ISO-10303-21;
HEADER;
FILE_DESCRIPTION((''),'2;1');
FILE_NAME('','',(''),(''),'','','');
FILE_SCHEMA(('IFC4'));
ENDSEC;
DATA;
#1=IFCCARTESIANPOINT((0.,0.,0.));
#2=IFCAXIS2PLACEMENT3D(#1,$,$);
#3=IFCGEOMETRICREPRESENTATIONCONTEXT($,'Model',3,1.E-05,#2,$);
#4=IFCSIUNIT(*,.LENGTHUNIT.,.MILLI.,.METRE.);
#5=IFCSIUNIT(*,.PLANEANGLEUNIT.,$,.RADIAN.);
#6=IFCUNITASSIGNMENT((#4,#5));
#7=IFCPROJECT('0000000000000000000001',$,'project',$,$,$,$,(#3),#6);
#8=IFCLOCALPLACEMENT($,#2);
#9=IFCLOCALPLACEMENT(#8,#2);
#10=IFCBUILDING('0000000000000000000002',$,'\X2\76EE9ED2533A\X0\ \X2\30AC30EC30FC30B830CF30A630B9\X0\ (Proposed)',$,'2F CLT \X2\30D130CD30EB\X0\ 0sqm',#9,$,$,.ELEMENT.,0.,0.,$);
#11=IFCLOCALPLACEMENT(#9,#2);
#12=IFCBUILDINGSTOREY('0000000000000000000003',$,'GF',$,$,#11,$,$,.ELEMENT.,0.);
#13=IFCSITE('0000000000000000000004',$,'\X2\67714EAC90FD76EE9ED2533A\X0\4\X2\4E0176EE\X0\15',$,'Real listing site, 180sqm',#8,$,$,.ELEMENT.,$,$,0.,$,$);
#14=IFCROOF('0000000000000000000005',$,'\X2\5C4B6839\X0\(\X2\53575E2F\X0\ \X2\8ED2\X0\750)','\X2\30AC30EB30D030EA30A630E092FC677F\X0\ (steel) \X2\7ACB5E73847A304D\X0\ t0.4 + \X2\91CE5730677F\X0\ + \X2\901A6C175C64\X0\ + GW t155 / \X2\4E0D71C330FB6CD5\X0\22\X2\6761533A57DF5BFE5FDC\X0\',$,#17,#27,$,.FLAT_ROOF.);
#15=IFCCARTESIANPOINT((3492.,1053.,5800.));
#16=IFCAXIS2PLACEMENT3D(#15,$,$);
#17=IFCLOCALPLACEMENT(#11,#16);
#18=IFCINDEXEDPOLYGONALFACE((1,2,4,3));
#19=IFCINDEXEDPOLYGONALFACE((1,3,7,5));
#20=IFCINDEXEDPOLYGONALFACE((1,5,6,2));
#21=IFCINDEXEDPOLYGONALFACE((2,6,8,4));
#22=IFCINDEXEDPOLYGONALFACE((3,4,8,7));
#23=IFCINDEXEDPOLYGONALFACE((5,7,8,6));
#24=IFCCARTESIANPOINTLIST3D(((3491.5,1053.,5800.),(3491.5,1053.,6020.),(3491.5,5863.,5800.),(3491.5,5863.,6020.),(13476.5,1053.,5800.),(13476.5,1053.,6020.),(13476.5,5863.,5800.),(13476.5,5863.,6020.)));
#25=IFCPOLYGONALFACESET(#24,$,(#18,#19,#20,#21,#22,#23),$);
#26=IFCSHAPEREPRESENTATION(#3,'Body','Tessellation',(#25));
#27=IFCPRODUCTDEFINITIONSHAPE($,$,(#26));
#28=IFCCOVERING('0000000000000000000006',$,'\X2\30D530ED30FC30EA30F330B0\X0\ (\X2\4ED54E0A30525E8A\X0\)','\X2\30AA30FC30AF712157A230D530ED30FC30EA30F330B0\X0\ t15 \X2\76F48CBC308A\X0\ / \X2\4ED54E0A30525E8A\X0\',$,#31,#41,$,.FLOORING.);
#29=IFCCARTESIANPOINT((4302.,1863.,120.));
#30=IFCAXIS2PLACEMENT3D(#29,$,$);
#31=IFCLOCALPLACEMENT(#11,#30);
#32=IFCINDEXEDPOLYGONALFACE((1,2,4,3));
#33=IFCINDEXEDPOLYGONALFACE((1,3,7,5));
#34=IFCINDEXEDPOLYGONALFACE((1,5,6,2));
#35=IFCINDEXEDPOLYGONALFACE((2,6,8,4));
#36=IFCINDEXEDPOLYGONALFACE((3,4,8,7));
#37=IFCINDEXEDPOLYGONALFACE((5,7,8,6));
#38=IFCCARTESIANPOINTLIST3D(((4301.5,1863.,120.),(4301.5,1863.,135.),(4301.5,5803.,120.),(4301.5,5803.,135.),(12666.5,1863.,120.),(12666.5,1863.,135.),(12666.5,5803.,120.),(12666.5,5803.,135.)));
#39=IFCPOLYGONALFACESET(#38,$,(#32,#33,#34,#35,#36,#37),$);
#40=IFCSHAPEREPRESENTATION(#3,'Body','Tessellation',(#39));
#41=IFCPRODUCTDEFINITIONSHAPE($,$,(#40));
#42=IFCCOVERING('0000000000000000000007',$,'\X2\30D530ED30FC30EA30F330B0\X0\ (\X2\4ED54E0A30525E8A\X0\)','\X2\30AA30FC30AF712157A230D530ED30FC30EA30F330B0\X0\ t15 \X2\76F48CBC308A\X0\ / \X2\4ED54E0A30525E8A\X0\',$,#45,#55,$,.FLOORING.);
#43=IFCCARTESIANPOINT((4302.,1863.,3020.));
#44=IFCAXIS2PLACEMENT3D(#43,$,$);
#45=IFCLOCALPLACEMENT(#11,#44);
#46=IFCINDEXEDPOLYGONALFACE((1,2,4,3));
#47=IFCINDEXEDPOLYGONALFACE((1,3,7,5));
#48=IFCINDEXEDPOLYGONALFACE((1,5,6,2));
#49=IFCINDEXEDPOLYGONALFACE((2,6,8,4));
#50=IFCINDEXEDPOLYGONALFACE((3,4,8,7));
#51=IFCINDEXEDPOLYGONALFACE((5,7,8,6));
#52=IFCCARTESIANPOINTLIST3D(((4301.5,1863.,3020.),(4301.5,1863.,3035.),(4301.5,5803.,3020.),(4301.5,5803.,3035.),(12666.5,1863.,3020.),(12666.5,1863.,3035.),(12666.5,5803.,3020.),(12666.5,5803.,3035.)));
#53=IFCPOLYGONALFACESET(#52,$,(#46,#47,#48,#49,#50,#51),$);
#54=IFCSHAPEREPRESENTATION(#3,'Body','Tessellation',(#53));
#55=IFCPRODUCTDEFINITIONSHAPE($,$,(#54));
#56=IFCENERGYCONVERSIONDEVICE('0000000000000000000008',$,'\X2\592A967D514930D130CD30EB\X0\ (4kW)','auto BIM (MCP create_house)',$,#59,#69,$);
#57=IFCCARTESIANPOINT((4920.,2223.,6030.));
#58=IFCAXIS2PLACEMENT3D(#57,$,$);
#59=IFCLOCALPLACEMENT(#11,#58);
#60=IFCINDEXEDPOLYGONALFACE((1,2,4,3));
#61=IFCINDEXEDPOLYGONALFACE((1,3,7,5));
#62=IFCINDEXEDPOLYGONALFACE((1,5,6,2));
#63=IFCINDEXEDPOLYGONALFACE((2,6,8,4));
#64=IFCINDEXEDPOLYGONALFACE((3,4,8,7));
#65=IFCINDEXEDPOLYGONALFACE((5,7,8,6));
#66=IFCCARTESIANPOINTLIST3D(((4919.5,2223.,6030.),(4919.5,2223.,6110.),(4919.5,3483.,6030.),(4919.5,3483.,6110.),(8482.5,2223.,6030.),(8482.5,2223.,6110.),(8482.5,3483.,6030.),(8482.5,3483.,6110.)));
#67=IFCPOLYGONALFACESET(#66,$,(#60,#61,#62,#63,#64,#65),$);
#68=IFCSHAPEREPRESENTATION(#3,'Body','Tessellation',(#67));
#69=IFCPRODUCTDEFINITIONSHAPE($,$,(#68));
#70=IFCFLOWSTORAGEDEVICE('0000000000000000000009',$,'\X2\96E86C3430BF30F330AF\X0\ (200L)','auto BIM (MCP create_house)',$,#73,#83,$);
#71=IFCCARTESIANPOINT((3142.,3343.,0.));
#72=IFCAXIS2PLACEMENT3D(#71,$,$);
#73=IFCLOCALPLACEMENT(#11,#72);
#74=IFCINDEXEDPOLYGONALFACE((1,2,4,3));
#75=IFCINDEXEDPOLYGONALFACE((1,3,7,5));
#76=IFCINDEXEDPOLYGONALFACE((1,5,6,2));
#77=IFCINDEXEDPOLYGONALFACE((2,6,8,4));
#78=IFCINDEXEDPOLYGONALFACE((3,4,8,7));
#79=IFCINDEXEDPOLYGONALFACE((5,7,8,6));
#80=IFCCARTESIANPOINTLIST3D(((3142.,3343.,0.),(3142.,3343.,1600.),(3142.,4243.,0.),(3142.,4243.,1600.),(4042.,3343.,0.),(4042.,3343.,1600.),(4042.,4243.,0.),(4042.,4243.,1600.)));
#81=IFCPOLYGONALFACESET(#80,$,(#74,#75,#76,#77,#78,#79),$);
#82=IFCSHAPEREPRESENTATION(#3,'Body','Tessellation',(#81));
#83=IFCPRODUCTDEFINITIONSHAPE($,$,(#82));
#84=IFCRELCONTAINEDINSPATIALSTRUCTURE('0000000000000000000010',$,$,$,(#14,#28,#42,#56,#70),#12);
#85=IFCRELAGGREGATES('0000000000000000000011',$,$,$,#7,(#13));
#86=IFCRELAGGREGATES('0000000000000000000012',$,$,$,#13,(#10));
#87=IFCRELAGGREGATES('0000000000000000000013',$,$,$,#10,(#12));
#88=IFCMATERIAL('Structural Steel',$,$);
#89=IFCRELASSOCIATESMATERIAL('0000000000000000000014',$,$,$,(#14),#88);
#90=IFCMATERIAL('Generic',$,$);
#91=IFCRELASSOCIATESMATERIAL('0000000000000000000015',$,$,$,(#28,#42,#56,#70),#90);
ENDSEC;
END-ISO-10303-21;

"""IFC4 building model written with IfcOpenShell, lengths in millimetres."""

from ifc_helpers import new_model, si_unit, frame, frame_2d, origin, place, context, project, spatial, rectangle, extrude, material, element, save


model = new_model("IFC4")

# Units and contexts
model_context = context("Model", 3, precision=1e-05, world=origin())
ifc_project = project(units=[si_unit("LENGTHUNIT", "METRE", prefix="MILLI"), si_unit("PLANEANGLEUNIT", "RADIAN")], contexts=[model_context])

# Site, building, storey
site_placement = place(None, origin())
site = spatial("IfcSite", under=ifc_project, at=site_placement, Name="東京都目黒区4丁目15", ObjectType="Real listing site, 180sqm", CompositionType="ELEMENT", RefElevation=0.0)
building_placement = place(site_placement, origin())
building = spatial("IfcBuilding", under=site, at=building_placement, Name="目黒区 ガレージハウス (Proposed)", ObjectType="2F CLT パネル 0sqm", CompositionType="ELEMENT", ElevationOfRefHeight=0.0, ElevationOfTerrain=0.0)
storey_placement = place(building_placement, origin())
storey = spatial("IfcBuildingStorey", under=building, at=storey_placement, Name="GF", CompositionType="ELEMENT", Elevation=0.0)

# Roof
ifc_material_1 = material(Name="Structural Steel")
for number, where, name in (
    (1, (3492.0, 1053.0, 5800.0), "屋根(南帯 軒750)"),
):
    element("IfcRoof", number, at=place(storey_placement, frame(where)), inside=storey, material=ifc_material_1, Name=name, Description="ガルバリウム鋼板 (steel) 立平葺き t0.4 + 野地板 + 通気層 + GW t155 / 不燃・法22条区域対応", PredefinedType="FLAT_ROOF", context=model_context, shape_type="SweptSolid", body=[
        extrude(rectangle(XDim=9985.0, YDim=4810.0, at=frame_2d((4992.0, 2405.0))), frame((3492.0, 1053.0, 5800.0)), (0.0, 0.0, 1.0), 220.0),
    ])

# Coverings
ifc_material_2 = material(Name="Generic")
covering_1_placement = place(storey_placement, frame((4302.0, 1863.0, 120.0)))
element("IfcCovering", 2, at=covering_1_placement, inside=storey, material=ifc_material_2, Name="フローリング (仕上げ床)", Description="オーク無垢フローリング t15 直貼り / 仕上げ床", PredefinedType="FLOORING", context=model_context, shape_type="SweptSolid", body=[
    extrude(rectangle(XDim=8365.0, YDim=3940.0, at=frame_2d((4182.0, 1970.0))), frame((4302.0, 1863.0, 120.0)), (0.0, 0.0, 1.0), 15.0),
])
covering_2_placement = place(storey_placement, frame((4302.0, 1863.0, 3020.0)))
element("IfcCovering", 3, at=covering_2_placement, inside=storey, material=ifc_material_2, Name="フローリング (仕上げ床)", Description="オーク無垢フローリング t15 直貼り / 仕上げ床", PredefinedType="FLOORING", context=model_context, shape_type="SweptSolid", body=[
    extrude(rectangle(XDim=8365.0, YDim=3940.0, at=frame_2d((4182.0, 1970.0))), frame((4302.0, 1863.0, 3020.0)), (0.0, 0.0, 1.0), 15.0),
])

# Energy conversion device
energy_conversion_device_placement = place(storey_placement, frame((4920.0, 2223.0, 6030.0)))
element("IfcEnergyConversionDevice", 4, at=energy_conversion_device_placement, inside=storey, material=ifc_material_2, Name="太陽光パネル (4kW)", Description="auto BIM (MCP create_house)", context=model_context, shape_type="SweptSolid", body=[
    extrude(rectangle(XDim=3563.0, YDim=1260.0, at=frame_2d((1781.0, 630.0))), frame((4920.0, 2223.0, 6030.0)), (0.0, 0.0, 1.0), 80.0),
])

# Flow storage device
flow_storage_device_placement = place(storey_placement, frame((3142.0, 3343.0, 0.0)))
element("IfcFlowStorageDevice", 5, at=flow_storage_device_placement, inside=storey, material=ifc_material_2, Name="雨水タンク (200L)", Description="auto BIM (MCP create_house)", context=model_context, shape_type="SweptSolid", body=[
    extrude(rectangle(XDim=900.0, YDim=900.0, at=frame_2d((450.0, 450.0))), frame((3142.0, 3343.0, 0.0)), (0.0, 0.0, 1.0), 1600.0),
])

save(model, "model.ifc")
